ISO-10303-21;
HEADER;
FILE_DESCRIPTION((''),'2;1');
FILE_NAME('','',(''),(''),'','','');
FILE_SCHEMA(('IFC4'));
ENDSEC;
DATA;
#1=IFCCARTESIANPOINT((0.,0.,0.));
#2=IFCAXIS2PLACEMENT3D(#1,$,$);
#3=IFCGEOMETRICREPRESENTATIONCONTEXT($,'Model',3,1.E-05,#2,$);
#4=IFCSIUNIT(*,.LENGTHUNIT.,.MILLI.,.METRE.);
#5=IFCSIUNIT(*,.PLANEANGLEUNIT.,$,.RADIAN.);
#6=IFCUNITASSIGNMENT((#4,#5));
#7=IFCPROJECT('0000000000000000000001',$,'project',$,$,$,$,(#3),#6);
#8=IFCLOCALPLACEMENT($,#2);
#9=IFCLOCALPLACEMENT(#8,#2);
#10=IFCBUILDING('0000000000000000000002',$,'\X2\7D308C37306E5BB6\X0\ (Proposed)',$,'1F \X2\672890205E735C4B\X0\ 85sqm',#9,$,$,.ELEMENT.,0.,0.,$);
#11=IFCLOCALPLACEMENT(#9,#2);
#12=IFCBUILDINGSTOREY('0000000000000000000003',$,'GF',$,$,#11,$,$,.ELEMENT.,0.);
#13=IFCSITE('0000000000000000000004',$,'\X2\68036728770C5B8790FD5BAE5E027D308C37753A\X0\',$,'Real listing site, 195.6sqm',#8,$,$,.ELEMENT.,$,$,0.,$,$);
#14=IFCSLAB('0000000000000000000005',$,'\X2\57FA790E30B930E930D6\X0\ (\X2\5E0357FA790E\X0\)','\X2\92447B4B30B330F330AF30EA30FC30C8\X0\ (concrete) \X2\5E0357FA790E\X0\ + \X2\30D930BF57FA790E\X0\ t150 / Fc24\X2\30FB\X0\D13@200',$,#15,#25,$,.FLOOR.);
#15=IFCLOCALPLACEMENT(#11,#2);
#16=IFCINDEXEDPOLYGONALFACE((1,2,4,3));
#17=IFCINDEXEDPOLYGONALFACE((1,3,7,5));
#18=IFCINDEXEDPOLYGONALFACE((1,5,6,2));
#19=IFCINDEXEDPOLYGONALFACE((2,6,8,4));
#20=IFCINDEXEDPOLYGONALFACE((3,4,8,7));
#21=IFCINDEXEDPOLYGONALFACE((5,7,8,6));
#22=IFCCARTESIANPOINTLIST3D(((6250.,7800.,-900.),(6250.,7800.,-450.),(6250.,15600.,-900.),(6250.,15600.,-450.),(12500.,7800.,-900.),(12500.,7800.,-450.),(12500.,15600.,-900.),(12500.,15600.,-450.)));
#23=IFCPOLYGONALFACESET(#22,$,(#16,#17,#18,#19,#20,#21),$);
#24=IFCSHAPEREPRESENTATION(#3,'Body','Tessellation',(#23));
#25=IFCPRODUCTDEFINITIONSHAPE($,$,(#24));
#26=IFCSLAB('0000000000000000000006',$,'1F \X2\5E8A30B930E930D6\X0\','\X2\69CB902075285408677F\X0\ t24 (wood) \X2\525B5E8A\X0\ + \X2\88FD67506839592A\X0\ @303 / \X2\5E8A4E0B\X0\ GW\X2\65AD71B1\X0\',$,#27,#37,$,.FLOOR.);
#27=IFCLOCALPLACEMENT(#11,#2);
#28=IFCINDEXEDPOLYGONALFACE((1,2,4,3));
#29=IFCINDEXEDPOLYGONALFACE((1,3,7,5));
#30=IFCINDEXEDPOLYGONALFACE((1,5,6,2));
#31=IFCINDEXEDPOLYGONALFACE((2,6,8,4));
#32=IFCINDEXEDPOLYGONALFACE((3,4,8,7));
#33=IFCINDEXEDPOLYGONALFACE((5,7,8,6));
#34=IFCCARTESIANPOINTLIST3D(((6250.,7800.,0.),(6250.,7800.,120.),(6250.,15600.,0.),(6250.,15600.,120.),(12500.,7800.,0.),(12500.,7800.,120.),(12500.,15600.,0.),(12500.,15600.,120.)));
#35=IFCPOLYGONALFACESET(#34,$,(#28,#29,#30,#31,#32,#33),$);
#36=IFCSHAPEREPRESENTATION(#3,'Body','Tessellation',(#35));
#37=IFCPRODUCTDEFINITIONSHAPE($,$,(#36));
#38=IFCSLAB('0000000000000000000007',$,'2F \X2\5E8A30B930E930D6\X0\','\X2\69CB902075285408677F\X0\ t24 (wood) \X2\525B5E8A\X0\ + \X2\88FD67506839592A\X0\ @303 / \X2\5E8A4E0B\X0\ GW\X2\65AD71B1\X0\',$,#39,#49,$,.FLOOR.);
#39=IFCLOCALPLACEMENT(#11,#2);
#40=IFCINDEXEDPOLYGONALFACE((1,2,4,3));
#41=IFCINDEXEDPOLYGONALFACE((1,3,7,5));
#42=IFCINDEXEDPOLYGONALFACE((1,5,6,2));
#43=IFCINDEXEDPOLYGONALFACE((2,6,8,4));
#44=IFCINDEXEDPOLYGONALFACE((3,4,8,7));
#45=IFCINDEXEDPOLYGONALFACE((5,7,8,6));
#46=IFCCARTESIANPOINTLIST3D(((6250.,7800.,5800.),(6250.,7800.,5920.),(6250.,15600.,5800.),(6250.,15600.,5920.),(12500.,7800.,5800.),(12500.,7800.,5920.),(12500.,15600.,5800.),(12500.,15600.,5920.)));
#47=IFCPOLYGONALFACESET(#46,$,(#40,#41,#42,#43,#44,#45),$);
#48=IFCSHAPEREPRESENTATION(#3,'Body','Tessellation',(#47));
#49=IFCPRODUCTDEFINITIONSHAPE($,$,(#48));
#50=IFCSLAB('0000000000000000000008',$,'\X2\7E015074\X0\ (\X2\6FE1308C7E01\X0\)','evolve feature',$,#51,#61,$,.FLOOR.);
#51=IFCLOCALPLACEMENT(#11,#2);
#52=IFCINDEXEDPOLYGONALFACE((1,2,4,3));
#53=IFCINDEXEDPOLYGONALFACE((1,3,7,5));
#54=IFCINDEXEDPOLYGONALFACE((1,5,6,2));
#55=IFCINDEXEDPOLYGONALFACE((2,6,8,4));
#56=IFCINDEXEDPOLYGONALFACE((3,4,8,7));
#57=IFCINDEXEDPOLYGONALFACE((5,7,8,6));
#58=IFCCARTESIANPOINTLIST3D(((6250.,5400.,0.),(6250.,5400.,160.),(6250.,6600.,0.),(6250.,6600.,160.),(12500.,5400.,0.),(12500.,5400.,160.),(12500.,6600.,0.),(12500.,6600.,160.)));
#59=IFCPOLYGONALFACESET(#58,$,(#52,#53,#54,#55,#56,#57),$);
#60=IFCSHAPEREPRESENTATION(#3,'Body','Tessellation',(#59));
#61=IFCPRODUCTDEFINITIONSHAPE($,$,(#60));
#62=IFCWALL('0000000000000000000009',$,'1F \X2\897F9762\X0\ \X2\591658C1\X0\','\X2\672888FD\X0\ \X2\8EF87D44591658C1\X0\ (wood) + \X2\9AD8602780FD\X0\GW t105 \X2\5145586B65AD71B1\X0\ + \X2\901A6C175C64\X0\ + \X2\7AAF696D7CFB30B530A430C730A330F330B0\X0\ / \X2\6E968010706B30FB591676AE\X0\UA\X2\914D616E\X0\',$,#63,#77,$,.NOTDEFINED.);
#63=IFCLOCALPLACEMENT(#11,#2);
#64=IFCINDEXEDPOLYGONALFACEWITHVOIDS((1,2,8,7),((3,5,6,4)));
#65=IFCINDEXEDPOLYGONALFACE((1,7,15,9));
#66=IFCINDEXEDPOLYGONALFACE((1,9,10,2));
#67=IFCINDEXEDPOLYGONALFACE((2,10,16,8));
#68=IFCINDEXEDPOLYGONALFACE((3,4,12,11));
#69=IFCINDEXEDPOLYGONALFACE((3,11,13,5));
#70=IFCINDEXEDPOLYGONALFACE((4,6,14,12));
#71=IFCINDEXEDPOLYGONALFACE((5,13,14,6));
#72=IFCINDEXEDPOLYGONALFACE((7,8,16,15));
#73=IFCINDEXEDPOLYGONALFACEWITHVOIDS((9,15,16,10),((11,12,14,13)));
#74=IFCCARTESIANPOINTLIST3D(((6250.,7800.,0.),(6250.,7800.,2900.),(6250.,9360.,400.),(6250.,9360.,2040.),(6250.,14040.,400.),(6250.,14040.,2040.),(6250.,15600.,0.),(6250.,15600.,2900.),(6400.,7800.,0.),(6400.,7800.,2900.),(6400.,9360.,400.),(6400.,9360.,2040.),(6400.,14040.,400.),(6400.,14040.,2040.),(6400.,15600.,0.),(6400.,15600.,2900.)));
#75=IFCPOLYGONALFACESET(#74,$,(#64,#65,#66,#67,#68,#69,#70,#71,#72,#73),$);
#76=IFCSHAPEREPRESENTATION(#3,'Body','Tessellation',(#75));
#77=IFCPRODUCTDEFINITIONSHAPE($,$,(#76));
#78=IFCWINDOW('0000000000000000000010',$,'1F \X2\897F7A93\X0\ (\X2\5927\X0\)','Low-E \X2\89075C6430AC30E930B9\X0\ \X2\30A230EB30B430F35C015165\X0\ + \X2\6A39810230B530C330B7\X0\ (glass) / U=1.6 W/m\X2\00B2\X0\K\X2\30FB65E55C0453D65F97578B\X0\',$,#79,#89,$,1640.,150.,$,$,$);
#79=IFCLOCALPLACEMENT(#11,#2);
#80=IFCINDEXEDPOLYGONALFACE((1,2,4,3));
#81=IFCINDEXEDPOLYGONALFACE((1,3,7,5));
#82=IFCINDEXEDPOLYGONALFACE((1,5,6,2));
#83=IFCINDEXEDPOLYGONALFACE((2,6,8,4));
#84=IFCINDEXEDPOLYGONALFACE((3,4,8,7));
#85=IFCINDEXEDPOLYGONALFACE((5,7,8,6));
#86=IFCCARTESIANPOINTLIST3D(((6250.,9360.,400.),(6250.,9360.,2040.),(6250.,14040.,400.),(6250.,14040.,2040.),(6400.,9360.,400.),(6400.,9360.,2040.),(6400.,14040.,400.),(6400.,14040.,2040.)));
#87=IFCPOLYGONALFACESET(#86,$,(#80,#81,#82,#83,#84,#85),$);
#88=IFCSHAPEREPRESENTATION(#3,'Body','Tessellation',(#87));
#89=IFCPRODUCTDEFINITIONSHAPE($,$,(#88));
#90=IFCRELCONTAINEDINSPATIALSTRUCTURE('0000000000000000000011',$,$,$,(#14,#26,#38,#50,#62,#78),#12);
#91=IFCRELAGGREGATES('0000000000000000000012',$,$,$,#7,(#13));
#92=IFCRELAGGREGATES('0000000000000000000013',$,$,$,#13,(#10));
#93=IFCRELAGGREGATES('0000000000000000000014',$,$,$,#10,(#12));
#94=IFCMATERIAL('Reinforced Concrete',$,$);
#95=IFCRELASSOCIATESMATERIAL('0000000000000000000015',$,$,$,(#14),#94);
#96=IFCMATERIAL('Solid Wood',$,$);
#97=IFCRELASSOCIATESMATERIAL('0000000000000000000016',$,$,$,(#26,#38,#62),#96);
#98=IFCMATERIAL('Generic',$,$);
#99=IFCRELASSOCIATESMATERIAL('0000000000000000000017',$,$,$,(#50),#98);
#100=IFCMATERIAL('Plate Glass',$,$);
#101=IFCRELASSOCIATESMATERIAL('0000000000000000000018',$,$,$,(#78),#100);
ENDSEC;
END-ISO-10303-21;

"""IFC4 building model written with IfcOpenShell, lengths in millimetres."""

from ifc_helpers import new_model, si_unit, frame, frame_2d, origin, place, context, project, spatial, rectangle, extrude, material, element, fill, save


model = new_model("IFC4")

# Units and contexts
model_context = context("Model", 3, precision=1e-05, world=origin())
ifc_project = project(units=[si_unit("LENGTHUNIT", "METRE", prefix="MILLI"), si_unit("PLANEANGLEUNIT", "RADIAN")], contexts=[model_context])

# Site, building, storey
site_placement = place(None, origin())
site = spatial("IfcSite", under=ifc_project, at=site_placement, Name="栃木県宇都宮市細谷町", ObjectType="Real listing site, 195.6sqm", CompositionType="ELEMENT", RefElevation=0.0)
building_placement = place(site_placement, origin())
building = spatial("IfcBuilding", under=site, at=building_placement, Name="細谷の家 (Proposed)", ObjectType="1F 木造平屋 85sqm", CompositionType="ELEMENT", ElevationOfRefHeight=0.0, ElevationOfTerrain=0.0)
storey_placement = place(building_placement, origin())
storey = spatial("IfcBuildingStorey", under=building, at=storey_placement, Name="GF", CompositionType="ELEMENT", Elevation=0.0)

# Slabs
ifc_material_1 = material(Name="Reinforced Concrete")
slab_1_placement = place(storey_placement, frame((3125.0, 3900.0, -450.0)))
element("IfcSlab", 1, at=slab_1_placement, inside=storey, material=ifc_material_1, Name="基礎スラブ (布基礎)", Description="鉄筋コンクリート (concrete) 布基礎 + ベタ基礎 t150 / Fc24・D13@200", PredefinedType="FLOOR", context=model_context, shape_type="SweptSolid", body=[
    extrude(rectangle(XDim=6250.0, YDim=7800.0, at=frame_2d((3125.0, 3900.0))), frame((3125.0, 3900.0, -450.0)), (0.0, 0.0, 1.0), 450.0),
])
ifc_material_2 = material(Name="Solid Wood")
slab_2_placement = place(storey_placement, frame((3125.0, 3900.0, 0.0)))
element("IfcSlab", 2, at=slab_2_placement, inside=storey, material=ifc_material_2, Name="1F 床スラブ", Description="構造用合板 t24 (wood) 剛床 + 製材根太 @303 / 床下 GW断熱", PredefinedType="FLOOR", context=model_context, shape_type="SweptSolid", body=[
    extrude(rectangle(XDim=6250.0, YDim=7800.0, at=frame_2d((3125.0, 3900.0))), frame((3125.0, 3900.0, 0.0)), (0.0, 0.0, 1.0), 120.0),
])
slab_3_placement = place(storey_placement, frame((3125.0, 3900.0, 2900.0)))
element("IfcSlab", 3, at=slab_3_placement, inside=storey, material=ifc_material_2, Name="2F 床スラブ", Description="構造用合板 t24 (wood) 剛床 + 製材根太 @303 / 床下 GW断熱", PredefinedType="FLOOR", context=model_context, shape_type="SweptSolid", body=[
    extrude(rectangle(XDim=6250.0, YDim=7800.0, at=frame_2d((3125.0, 3900.0))), frame((3125.0, 3900.0, 2900.0)), (0.0, 0.0, 1.0), 120.0),
])
ifc_material_3 = material(Name="Generic")
slab_4_placement = place(storey_placement, frame((3125.0, 2700.0, 0.0)))
element("IfcSlab", 4, at=slab_4_placement, inside=storey, material=ifc_material_3, Name="縁側 (濡れ縁)", Description="evolve feature", PredefinedType="FLOOR", context=model_context, shape_type="SweptSolid", body=[
    extrude(rectangle(XDim=6250.0, YDim=1200.0, at=frame_2d((3125.0, 600.0))), frame((3125.0, 2700.0, 0.0)), (0.0, 0.0, 1.0), 160.0),
])

# Shared definitions
ifc_material_4 = material(Name="Plate Glass")

# Wall, opening, window
wall_1_placement = place(storey_placement, frame((3125.0, 3900.0, 0.0)))
wall_1 = element("IfcWall", 5, at=wall_1_placement, inside=storey, material=ifc_material_2, Name="1F 西面 外壁", Description="木製 軸組外壁 (wood) + 高性能GW t105 充填断熱 + 通気層 + 窯業系サイディング / 準耐火・外皮UA配慮", PredefinedType="NOTDEFINED", context=model_context, shape_type="SweptSolid", body=[
    extrude(rectangle(XDim=150.0, YDim=7800.0, at=frame_2d((75.0, 3900.0))), frame((3125.0, 3900.0, 0.0)), (0.0, 0.0, 1.0), 2900.0),
])
opening_1_placement = place(storey_placement, frame((3125.0, 4680.0, 200.0)))
opening_1 = element("IfcOpeningElement", 6, at=opening_1_placement, cuts=wall_1, PredefinedType="NOTDEFINED", context=model_context, shape_type="SweptSolid", body=[
    extrude(rectangle(XDim=150.0, YDim=4680.0, at=frame_2d((75.0, 2340.0))), frame((3125.0, 4680.0, 200.0)), (0.0, 0.0, 1.0), 1640.0),
])
window_1_placement = place(storey_placement, frame((3125.0, 4680.0, 200.0)))
window_1 = element("IfcWindow", 7, at=window_1_placement, inside=storey, material=ifc_material_4, Name="1F 西窓 (大)", Description="Low-E 複層ガラス アルゴン封入 + 樹脂サッシ (glass) / U=1.6 W/m²K・日射取得型", OverallHeight=1640.0, OverallWidth=150.0, context=model_context, shape_type="SweptSolid", body=[
    extrude(rectangle(XDim=150.0, YDim=4680.0, at=frame_2d((75.0, 2340.0))), frame((3125.0, 4680.0, 200.0)), (0.0, 0.0, 1.0), 1640.0),
])
fill(opening_1, window_1)

save(model, "model.ifc")
